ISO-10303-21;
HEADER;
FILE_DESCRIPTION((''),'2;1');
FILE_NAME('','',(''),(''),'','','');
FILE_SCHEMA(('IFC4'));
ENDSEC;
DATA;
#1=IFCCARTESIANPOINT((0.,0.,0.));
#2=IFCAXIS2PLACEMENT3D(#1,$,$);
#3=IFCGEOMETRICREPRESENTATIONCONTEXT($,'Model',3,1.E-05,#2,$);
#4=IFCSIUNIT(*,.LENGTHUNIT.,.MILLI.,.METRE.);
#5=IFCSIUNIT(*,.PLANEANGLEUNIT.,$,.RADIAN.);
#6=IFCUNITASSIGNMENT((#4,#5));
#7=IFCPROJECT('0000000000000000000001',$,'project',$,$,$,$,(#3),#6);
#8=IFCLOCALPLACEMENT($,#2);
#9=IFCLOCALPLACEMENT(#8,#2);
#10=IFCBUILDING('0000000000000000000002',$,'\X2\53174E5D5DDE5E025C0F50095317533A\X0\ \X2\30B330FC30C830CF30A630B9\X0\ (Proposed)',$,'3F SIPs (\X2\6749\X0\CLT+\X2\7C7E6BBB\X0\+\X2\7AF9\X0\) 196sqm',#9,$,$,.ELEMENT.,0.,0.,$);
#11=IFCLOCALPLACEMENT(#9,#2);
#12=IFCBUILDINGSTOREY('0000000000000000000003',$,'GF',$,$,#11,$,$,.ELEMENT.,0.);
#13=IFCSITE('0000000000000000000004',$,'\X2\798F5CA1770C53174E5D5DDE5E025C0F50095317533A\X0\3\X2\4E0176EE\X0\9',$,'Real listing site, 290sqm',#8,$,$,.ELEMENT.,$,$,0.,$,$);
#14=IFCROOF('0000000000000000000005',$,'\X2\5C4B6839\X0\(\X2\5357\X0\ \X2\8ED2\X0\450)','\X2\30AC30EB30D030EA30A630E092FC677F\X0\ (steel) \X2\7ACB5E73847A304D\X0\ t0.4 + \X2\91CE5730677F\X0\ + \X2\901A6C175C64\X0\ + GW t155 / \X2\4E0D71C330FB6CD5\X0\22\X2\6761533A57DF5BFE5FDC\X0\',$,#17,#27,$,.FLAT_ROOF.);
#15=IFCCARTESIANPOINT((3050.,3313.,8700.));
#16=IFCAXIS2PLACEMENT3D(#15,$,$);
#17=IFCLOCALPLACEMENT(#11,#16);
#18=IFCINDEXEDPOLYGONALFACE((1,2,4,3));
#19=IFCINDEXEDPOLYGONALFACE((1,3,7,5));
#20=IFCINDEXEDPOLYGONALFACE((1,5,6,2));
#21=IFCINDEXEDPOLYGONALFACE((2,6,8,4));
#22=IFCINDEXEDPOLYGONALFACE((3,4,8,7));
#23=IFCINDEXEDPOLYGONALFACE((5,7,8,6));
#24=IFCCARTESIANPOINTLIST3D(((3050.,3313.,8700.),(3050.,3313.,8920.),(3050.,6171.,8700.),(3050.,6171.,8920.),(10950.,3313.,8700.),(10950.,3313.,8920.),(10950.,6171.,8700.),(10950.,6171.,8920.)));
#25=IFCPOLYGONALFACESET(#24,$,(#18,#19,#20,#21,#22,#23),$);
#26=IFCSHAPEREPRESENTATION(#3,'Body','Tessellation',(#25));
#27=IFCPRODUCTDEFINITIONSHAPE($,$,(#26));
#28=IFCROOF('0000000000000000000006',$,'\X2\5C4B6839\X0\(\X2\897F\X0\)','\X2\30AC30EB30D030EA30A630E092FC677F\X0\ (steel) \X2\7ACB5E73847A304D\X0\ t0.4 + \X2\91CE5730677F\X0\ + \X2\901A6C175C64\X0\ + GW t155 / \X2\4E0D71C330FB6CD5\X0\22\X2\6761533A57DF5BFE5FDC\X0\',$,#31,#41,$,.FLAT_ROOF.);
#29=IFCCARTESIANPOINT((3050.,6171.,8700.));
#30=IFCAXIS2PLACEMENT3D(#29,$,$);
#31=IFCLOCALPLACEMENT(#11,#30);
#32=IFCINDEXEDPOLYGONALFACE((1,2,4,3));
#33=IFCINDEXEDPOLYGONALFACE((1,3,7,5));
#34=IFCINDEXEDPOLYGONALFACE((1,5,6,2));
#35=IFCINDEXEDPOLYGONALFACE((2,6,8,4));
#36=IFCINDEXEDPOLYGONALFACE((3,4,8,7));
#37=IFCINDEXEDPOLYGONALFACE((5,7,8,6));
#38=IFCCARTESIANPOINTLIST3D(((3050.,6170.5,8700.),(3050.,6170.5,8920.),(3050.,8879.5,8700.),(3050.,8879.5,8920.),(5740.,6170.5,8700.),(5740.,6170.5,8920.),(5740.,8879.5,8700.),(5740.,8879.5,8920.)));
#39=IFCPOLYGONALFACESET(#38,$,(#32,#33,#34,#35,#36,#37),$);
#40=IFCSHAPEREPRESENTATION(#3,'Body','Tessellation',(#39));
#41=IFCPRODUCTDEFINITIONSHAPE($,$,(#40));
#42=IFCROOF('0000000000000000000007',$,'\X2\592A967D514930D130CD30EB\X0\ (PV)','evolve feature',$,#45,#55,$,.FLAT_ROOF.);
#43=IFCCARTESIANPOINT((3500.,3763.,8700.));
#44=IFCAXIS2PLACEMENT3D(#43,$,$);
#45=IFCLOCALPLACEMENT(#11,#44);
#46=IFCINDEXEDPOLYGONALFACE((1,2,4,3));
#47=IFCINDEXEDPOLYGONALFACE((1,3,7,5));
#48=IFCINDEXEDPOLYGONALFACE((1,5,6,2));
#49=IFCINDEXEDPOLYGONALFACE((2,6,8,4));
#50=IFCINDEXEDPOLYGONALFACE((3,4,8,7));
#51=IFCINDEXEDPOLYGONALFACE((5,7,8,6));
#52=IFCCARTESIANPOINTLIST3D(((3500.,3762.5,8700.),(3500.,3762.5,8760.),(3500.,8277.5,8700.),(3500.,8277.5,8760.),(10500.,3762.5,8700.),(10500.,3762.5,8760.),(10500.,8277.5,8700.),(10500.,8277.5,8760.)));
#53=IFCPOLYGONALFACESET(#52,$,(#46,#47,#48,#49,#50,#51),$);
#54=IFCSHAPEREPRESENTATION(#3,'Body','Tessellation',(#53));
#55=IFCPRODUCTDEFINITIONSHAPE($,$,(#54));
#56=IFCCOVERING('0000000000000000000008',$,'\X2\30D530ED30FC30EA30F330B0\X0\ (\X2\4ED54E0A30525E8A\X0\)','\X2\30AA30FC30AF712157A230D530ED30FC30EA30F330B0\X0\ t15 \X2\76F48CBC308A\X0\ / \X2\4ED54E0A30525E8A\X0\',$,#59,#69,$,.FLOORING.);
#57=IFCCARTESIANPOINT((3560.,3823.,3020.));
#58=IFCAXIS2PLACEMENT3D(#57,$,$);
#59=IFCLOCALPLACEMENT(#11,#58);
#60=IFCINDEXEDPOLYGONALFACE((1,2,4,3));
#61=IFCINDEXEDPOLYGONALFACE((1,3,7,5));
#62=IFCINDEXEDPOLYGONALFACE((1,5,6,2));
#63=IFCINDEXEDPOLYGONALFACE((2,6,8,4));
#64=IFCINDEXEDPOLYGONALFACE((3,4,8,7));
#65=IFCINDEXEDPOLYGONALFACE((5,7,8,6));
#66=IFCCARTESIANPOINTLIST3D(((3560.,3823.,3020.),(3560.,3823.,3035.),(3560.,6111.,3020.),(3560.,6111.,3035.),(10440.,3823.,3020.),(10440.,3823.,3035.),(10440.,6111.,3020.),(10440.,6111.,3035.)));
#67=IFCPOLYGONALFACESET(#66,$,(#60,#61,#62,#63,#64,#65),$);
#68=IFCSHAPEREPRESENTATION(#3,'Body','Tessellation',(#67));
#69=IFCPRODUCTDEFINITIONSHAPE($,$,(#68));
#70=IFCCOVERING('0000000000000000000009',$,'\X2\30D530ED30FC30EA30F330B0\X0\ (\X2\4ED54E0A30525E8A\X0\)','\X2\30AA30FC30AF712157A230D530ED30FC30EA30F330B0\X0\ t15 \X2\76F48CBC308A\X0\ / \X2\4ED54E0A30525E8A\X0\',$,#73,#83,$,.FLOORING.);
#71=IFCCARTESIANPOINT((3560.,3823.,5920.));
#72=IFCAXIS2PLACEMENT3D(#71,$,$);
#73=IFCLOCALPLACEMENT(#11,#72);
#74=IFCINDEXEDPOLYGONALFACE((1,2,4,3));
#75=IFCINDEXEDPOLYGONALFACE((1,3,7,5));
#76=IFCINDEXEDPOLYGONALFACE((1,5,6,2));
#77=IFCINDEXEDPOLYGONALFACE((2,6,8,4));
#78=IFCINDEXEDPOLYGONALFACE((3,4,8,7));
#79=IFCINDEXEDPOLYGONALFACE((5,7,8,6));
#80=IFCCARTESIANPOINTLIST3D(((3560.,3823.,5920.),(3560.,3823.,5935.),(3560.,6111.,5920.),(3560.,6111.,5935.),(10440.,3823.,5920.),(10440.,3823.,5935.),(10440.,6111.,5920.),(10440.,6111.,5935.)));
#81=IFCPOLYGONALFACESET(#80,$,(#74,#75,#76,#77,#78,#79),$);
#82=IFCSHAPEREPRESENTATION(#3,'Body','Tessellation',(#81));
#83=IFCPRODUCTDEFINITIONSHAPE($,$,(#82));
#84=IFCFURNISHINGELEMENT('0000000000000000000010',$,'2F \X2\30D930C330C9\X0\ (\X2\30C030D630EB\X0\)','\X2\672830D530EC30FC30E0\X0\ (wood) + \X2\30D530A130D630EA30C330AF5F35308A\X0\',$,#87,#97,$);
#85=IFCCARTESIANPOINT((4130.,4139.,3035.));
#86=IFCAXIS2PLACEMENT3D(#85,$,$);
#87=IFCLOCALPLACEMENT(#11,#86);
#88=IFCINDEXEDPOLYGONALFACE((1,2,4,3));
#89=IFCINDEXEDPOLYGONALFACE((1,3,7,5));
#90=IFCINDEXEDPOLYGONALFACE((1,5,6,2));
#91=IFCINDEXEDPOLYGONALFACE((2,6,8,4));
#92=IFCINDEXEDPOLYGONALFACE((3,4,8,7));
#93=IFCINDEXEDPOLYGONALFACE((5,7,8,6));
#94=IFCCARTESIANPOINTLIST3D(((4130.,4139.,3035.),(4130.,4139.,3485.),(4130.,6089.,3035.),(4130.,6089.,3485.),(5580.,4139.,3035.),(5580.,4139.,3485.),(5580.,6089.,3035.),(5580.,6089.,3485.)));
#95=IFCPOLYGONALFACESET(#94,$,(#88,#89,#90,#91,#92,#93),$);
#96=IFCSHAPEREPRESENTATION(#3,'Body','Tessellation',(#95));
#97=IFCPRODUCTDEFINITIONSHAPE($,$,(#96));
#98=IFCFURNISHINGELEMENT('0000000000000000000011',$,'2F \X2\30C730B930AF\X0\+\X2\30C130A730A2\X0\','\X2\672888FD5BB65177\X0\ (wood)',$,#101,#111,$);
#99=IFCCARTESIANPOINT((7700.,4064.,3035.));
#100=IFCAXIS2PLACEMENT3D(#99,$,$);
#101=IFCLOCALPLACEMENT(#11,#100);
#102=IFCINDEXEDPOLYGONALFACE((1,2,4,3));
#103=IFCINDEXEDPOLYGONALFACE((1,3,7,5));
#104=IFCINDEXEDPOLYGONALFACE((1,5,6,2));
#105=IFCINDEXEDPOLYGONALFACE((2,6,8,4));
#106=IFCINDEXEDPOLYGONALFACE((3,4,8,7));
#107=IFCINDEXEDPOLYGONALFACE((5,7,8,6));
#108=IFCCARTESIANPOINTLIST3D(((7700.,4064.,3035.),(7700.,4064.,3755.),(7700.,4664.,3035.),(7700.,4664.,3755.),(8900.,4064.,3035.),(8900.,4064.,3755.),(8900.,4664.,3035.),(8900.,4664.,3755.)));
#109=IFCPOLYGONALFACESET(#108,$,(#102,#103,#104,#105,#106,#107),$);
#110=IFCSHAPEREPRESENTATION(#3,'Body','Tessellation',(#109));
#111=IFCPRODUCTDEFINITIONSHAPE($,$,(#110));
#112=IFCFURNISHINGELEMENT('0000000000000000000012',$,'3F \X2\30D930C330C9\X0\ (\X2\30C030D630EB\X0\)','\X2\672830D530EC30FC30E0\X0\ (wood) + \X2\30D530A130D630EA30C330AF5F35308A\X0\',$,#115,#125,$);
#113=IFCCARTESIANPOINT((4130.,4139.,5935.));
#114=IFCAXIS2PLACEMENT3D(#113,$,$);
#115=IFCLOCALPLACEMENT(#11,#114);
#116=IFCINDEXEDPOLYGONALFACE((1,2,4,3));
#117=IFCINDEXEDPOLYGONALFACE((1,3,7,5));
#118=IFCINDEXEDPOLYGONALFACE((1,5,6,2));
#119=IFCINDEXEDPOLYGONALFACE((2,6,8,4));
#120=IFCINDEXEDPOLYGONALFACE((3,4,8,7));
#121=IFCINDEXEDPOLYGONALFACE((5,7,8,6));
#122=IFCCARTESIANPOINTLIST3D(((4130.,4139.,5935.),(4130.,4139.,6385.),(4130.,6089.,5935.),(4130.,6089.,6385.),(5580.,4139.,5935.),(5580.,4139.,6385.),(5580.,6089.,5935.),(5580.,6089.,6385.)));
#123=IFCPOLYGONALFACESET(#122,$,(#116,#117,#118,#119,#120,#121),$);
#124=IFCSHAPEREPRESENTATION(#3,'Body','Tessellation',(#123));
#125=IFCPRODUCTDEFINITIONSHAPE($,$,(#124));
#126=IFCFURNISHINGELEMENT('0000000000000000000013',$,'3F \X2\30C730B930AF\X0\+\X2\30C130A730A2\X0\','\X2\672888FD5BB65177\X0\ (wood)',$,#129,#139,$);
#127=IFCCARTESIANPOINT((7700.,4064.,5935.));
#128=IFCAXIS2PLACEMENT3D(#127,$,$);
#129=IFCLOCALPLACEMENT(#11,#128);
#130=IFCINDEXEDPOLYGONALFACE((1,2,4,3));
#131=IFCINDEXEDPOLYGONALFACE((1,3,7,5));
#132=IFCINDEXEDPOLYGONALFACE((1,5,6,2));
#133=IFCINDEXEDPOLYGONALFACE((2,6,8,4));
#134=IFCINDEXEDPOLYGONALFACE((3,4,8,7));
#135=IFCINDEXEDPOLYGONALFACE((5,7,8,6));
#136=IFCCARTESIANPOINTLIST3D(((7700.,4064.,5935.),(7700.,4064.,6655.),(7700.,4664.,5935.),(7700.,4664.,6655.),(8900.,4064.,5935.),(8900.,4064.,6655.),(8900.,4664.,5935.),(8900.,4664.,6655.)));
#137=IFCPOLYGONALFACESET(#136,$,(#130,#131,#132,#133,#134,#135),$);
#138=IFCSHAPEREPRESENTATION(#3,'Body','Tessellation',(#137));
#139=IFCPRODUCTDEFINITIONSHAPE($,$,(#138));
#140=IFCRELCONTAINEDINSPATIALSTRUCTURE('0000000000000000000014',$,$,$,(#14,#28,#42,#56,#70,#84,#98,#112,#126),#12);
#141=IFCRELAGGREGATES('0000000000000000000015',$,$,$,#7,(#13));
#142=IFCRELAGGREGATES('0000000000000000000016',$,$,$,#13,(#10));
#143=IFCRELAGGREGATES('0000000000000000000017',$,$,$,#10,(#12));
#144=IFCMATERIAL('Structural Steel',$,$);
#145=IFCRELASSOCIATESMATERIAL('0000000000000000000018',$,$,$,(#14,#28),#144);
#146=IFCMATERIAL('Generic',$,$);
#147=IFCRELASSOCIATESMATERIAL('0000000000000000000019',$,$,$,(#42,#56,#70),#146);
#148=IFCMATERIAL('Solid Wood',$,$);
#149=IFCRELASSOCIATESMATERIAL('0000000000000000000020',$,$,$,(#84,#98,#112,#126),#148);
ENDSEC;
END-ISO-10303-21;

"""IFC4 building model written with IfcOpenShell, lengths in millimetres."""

from ifc_helpers import new_model, si_unit, frame, frame_2d, origin, place, context, project, spatial, rectangle, extrude, material, element, save


model = new_model("IFC4")

# Units and contexts
model_context = context("Model", 3, precision=1e-05, world=origin())
ifc_project = project(units=[si_unit("LENGTHUNIT", "METRE", prefix="MILLI"), si_unit("PLANEANGLEUNIT", "RADIAN")], contexts=[model_context])

# Site, building, storey
site_placement = place(None, origin())
site = spatial("IfcSite", under=ifc_project, at=site_placement, Name="福岡県北九州市小倉北区3丁目9", ObjectType="Real listing site, 290sqm", CompositionType="ELEMENT", RefElevation=0.0)
building_placement = place(site_placement, origin())
building = spatial("IfcBuilding", under=site, at=building_placement, Name="北九州市小倉北区 コートハウス (Proposed)", ObjectType="3F SIPs (杉CLT+籾殻+竹) 196sqm", CompositionType="ELEMENT", ElevationOfRefHeight=0.0, ElevationOfTerrain=0.0)
storey_placement = place(building_placement, origin())
storey = spatial("IfcBuildingStorey", under=building, at=storey_placement, Name="GF", CompositionType="ELEMENT", Elevation=0.0)

# Shared definitions
ifc_material_1 = material(Name="Solid Wood")

# Roofs
ifc_material_2 = material(Name="Structural Steel")
roof_1_placement = place(storey_placement, frame((3050.0, 3313.0, 8700.0)))
element("IfcRoof", 1, at=roof_1_placement, inside=storey, material=ifc_material_2, Name="屋根(南 軒450)", Description="ガルバリウム鋼板 (steel) 立平葺き t0.4 + 野地板 + 通気層 + GW t155 / 不燃・法22条区域対応", PredefinedType="FLAT_ROOF", context=model_context, shape_type="SweptSolid", body=[
    extrude(rectangle(XDim=7900.0, YDim=2858.0, at=frame_2d((3950.0, 1429.0))), frame((3050.0, 3313.0, 8700.0)), (0.0, 0.0, 1.0), 220.0),
])
roof_2_placement = place(storey_placement, frame((3050.0, 6171.0, 8700.0)))
element("IfcRoof", 2, at=roof_2_placement, inside=storey, material=ifc_material_2, Name="屋根(西)", Description="ガルバリウム鋼板 (steel) 立平葺き t0.4 + 野地板 + 通気層 + GW t155 / 不燃・法22条区域対応", PredefinedType="FLAT_ROOF", context=model_context, shape_type="SweptSolid", body=[
    extrude(rectangle(XDim=2690.0, YDim=2709.0, at=frame_2d((1345.0, 1354.0))), frame((3050.0, 6171.0, 8700.0)), (0.0, 0.0, 1.0), 220.0),
])
ifc_material_3 = material(Name="Generic")
roof_3_placement = place(storey_placement, frame((3500.0, 3763.0, 8700.0)))
element("IfcRoof", 3, at=roof_3_placement, inside=storey, material=ifc_material_3, Name="太陽光パネル (PV)", Description="evolve feature", PredefinedType="FLAT_ROOF", context=model_context, shape_type="SweptSolid", body=[
    extrude(rectangle(XDim=7000.0, YDim=4515.0, at=frame_2d((3500.0, 2257.0))), frame((3500.0, 3763.0, 8700.0)), (0.0, 0.0, 1.0), 60.0),
])

# Coverings
covering_1_placement = place(storey_placement, frame((3560.0, 3823.0, 3020.0)))
element("IfcCovering", 4, at=covering_1_placement, inside=storey, material=ifc_material_3, Name="フローリング (仕上げ床)", Description="オーク無垢フローリング t15 直貼り / 仕上げ床", PredefinedType="FLOORING", context=model_context, shape_type="SweptSolid", body=[
    extrude(rectangle(XDim=6880.0, YDim=2288.0, at=frame_2d((3440.0, 1144.0))), frame((3560.0, 3823.0, 3020.0)), (0.0, 0.0, 1.0), 15.0),
])
covering_2_placement = place(storey_placement, frame((3560.0, 3823.0, 5920.0)))
element("IfcCovering", 5, at=covering_2_placement, inside=storey, material=ifc_material_3, Name="フローリング (仕上げ床)", Description="オーク無垢フローリング t15 直貼り / 仕上げ床", PredefinedType="FLOORING", context=model_context, shape_type="SweptSolid", body=[
    extrude(rectangle(XDim=6880.0, YDim=2288.0, at=frame_2d((3440.0, 1144.0))), frame((3560.0, 3823.0, 5920.0)), (0.0, 0.0, 1.0), 15.0),
])

# Furnishing elements
furnishing_1_placement = place(storey_placement, frame((4130.0, 4139.0, 3035.0)))
element("IfcFurnishingElement", 6, at=furnishing_1_placement, inside=storey, material=ifc_material_1, Name="2F ベッド (ダブル)", Description="木フレーム (wood) + ファブリック張り", context=model_context, shape_type="SweptSolid", body=[
    extrude(rectangle(XDim=1450.0, YDim=1950.0, at=frame_2d((725.0, 975.0))), frame((4130.0, 4139.0, 3035.0)), (0.0, 0.0, 1.0), 450.0),
])
furnishing_2_placement = place(storey_placement, frame((7700.0, 4064.0, 3035.0)))
element("IfcFurnishingElement", 7, at=furnishing_2_placement, inside=storey, material=ifc_material_1, Name="2F デスク+チェア", Description="木製家具 (wood)", context=model_context, shape_type="SweptSolid", body=[
    extrude(rectangle(XDim=1200.0, YDim=600.0, at=frame_2d((600.0, 300.0))), frame((7700.0, 4064.0, 3035.0)), (0.0, 0.0, 1.0), 720.0),
])
furnishing_3_placement = place(storey_placement, frame((4130.0, 4139.0, 5935.0)))
element("IfcFurnishingElement", 8, at=furnishing_3_placement, inside=storey, material=ifc_material_1, Name="3F ベッド (ダブル)", Description="木フレーム (wood) + ファブリック張り", context=model_context, shape_type="SweptSolid", body=[
    extrude(rectangle(XDim=1450.0, YDim=1950.0, at=frame_2d((725.0, 975.0))), frame((4130.0, 4139.0, 5935.0)), (0.0, 0.0, 1.0), 450.0),
])
furnishing_4_placement = place(storey_placement, frame((7700.0, 4064.0, 5935.0)))
element("IfcFurnishingElement", 9, at=furnishing_4_placement, inside=storey, material=ifc_material_1, Name="3F デスク+チェア", Description="木製家具 (wood)", context=model_context, shape_type="SweptSolid", body=[
    extrude(rectangle(XDim=1200.0, YDim=600.0, at=frame_2d((600.0, 300.0))), frame((7700.0, 4064.0, 5935.0)), (0.0, 0.0, 1.0), 720.0),
])

save(model, "model.ifc")
